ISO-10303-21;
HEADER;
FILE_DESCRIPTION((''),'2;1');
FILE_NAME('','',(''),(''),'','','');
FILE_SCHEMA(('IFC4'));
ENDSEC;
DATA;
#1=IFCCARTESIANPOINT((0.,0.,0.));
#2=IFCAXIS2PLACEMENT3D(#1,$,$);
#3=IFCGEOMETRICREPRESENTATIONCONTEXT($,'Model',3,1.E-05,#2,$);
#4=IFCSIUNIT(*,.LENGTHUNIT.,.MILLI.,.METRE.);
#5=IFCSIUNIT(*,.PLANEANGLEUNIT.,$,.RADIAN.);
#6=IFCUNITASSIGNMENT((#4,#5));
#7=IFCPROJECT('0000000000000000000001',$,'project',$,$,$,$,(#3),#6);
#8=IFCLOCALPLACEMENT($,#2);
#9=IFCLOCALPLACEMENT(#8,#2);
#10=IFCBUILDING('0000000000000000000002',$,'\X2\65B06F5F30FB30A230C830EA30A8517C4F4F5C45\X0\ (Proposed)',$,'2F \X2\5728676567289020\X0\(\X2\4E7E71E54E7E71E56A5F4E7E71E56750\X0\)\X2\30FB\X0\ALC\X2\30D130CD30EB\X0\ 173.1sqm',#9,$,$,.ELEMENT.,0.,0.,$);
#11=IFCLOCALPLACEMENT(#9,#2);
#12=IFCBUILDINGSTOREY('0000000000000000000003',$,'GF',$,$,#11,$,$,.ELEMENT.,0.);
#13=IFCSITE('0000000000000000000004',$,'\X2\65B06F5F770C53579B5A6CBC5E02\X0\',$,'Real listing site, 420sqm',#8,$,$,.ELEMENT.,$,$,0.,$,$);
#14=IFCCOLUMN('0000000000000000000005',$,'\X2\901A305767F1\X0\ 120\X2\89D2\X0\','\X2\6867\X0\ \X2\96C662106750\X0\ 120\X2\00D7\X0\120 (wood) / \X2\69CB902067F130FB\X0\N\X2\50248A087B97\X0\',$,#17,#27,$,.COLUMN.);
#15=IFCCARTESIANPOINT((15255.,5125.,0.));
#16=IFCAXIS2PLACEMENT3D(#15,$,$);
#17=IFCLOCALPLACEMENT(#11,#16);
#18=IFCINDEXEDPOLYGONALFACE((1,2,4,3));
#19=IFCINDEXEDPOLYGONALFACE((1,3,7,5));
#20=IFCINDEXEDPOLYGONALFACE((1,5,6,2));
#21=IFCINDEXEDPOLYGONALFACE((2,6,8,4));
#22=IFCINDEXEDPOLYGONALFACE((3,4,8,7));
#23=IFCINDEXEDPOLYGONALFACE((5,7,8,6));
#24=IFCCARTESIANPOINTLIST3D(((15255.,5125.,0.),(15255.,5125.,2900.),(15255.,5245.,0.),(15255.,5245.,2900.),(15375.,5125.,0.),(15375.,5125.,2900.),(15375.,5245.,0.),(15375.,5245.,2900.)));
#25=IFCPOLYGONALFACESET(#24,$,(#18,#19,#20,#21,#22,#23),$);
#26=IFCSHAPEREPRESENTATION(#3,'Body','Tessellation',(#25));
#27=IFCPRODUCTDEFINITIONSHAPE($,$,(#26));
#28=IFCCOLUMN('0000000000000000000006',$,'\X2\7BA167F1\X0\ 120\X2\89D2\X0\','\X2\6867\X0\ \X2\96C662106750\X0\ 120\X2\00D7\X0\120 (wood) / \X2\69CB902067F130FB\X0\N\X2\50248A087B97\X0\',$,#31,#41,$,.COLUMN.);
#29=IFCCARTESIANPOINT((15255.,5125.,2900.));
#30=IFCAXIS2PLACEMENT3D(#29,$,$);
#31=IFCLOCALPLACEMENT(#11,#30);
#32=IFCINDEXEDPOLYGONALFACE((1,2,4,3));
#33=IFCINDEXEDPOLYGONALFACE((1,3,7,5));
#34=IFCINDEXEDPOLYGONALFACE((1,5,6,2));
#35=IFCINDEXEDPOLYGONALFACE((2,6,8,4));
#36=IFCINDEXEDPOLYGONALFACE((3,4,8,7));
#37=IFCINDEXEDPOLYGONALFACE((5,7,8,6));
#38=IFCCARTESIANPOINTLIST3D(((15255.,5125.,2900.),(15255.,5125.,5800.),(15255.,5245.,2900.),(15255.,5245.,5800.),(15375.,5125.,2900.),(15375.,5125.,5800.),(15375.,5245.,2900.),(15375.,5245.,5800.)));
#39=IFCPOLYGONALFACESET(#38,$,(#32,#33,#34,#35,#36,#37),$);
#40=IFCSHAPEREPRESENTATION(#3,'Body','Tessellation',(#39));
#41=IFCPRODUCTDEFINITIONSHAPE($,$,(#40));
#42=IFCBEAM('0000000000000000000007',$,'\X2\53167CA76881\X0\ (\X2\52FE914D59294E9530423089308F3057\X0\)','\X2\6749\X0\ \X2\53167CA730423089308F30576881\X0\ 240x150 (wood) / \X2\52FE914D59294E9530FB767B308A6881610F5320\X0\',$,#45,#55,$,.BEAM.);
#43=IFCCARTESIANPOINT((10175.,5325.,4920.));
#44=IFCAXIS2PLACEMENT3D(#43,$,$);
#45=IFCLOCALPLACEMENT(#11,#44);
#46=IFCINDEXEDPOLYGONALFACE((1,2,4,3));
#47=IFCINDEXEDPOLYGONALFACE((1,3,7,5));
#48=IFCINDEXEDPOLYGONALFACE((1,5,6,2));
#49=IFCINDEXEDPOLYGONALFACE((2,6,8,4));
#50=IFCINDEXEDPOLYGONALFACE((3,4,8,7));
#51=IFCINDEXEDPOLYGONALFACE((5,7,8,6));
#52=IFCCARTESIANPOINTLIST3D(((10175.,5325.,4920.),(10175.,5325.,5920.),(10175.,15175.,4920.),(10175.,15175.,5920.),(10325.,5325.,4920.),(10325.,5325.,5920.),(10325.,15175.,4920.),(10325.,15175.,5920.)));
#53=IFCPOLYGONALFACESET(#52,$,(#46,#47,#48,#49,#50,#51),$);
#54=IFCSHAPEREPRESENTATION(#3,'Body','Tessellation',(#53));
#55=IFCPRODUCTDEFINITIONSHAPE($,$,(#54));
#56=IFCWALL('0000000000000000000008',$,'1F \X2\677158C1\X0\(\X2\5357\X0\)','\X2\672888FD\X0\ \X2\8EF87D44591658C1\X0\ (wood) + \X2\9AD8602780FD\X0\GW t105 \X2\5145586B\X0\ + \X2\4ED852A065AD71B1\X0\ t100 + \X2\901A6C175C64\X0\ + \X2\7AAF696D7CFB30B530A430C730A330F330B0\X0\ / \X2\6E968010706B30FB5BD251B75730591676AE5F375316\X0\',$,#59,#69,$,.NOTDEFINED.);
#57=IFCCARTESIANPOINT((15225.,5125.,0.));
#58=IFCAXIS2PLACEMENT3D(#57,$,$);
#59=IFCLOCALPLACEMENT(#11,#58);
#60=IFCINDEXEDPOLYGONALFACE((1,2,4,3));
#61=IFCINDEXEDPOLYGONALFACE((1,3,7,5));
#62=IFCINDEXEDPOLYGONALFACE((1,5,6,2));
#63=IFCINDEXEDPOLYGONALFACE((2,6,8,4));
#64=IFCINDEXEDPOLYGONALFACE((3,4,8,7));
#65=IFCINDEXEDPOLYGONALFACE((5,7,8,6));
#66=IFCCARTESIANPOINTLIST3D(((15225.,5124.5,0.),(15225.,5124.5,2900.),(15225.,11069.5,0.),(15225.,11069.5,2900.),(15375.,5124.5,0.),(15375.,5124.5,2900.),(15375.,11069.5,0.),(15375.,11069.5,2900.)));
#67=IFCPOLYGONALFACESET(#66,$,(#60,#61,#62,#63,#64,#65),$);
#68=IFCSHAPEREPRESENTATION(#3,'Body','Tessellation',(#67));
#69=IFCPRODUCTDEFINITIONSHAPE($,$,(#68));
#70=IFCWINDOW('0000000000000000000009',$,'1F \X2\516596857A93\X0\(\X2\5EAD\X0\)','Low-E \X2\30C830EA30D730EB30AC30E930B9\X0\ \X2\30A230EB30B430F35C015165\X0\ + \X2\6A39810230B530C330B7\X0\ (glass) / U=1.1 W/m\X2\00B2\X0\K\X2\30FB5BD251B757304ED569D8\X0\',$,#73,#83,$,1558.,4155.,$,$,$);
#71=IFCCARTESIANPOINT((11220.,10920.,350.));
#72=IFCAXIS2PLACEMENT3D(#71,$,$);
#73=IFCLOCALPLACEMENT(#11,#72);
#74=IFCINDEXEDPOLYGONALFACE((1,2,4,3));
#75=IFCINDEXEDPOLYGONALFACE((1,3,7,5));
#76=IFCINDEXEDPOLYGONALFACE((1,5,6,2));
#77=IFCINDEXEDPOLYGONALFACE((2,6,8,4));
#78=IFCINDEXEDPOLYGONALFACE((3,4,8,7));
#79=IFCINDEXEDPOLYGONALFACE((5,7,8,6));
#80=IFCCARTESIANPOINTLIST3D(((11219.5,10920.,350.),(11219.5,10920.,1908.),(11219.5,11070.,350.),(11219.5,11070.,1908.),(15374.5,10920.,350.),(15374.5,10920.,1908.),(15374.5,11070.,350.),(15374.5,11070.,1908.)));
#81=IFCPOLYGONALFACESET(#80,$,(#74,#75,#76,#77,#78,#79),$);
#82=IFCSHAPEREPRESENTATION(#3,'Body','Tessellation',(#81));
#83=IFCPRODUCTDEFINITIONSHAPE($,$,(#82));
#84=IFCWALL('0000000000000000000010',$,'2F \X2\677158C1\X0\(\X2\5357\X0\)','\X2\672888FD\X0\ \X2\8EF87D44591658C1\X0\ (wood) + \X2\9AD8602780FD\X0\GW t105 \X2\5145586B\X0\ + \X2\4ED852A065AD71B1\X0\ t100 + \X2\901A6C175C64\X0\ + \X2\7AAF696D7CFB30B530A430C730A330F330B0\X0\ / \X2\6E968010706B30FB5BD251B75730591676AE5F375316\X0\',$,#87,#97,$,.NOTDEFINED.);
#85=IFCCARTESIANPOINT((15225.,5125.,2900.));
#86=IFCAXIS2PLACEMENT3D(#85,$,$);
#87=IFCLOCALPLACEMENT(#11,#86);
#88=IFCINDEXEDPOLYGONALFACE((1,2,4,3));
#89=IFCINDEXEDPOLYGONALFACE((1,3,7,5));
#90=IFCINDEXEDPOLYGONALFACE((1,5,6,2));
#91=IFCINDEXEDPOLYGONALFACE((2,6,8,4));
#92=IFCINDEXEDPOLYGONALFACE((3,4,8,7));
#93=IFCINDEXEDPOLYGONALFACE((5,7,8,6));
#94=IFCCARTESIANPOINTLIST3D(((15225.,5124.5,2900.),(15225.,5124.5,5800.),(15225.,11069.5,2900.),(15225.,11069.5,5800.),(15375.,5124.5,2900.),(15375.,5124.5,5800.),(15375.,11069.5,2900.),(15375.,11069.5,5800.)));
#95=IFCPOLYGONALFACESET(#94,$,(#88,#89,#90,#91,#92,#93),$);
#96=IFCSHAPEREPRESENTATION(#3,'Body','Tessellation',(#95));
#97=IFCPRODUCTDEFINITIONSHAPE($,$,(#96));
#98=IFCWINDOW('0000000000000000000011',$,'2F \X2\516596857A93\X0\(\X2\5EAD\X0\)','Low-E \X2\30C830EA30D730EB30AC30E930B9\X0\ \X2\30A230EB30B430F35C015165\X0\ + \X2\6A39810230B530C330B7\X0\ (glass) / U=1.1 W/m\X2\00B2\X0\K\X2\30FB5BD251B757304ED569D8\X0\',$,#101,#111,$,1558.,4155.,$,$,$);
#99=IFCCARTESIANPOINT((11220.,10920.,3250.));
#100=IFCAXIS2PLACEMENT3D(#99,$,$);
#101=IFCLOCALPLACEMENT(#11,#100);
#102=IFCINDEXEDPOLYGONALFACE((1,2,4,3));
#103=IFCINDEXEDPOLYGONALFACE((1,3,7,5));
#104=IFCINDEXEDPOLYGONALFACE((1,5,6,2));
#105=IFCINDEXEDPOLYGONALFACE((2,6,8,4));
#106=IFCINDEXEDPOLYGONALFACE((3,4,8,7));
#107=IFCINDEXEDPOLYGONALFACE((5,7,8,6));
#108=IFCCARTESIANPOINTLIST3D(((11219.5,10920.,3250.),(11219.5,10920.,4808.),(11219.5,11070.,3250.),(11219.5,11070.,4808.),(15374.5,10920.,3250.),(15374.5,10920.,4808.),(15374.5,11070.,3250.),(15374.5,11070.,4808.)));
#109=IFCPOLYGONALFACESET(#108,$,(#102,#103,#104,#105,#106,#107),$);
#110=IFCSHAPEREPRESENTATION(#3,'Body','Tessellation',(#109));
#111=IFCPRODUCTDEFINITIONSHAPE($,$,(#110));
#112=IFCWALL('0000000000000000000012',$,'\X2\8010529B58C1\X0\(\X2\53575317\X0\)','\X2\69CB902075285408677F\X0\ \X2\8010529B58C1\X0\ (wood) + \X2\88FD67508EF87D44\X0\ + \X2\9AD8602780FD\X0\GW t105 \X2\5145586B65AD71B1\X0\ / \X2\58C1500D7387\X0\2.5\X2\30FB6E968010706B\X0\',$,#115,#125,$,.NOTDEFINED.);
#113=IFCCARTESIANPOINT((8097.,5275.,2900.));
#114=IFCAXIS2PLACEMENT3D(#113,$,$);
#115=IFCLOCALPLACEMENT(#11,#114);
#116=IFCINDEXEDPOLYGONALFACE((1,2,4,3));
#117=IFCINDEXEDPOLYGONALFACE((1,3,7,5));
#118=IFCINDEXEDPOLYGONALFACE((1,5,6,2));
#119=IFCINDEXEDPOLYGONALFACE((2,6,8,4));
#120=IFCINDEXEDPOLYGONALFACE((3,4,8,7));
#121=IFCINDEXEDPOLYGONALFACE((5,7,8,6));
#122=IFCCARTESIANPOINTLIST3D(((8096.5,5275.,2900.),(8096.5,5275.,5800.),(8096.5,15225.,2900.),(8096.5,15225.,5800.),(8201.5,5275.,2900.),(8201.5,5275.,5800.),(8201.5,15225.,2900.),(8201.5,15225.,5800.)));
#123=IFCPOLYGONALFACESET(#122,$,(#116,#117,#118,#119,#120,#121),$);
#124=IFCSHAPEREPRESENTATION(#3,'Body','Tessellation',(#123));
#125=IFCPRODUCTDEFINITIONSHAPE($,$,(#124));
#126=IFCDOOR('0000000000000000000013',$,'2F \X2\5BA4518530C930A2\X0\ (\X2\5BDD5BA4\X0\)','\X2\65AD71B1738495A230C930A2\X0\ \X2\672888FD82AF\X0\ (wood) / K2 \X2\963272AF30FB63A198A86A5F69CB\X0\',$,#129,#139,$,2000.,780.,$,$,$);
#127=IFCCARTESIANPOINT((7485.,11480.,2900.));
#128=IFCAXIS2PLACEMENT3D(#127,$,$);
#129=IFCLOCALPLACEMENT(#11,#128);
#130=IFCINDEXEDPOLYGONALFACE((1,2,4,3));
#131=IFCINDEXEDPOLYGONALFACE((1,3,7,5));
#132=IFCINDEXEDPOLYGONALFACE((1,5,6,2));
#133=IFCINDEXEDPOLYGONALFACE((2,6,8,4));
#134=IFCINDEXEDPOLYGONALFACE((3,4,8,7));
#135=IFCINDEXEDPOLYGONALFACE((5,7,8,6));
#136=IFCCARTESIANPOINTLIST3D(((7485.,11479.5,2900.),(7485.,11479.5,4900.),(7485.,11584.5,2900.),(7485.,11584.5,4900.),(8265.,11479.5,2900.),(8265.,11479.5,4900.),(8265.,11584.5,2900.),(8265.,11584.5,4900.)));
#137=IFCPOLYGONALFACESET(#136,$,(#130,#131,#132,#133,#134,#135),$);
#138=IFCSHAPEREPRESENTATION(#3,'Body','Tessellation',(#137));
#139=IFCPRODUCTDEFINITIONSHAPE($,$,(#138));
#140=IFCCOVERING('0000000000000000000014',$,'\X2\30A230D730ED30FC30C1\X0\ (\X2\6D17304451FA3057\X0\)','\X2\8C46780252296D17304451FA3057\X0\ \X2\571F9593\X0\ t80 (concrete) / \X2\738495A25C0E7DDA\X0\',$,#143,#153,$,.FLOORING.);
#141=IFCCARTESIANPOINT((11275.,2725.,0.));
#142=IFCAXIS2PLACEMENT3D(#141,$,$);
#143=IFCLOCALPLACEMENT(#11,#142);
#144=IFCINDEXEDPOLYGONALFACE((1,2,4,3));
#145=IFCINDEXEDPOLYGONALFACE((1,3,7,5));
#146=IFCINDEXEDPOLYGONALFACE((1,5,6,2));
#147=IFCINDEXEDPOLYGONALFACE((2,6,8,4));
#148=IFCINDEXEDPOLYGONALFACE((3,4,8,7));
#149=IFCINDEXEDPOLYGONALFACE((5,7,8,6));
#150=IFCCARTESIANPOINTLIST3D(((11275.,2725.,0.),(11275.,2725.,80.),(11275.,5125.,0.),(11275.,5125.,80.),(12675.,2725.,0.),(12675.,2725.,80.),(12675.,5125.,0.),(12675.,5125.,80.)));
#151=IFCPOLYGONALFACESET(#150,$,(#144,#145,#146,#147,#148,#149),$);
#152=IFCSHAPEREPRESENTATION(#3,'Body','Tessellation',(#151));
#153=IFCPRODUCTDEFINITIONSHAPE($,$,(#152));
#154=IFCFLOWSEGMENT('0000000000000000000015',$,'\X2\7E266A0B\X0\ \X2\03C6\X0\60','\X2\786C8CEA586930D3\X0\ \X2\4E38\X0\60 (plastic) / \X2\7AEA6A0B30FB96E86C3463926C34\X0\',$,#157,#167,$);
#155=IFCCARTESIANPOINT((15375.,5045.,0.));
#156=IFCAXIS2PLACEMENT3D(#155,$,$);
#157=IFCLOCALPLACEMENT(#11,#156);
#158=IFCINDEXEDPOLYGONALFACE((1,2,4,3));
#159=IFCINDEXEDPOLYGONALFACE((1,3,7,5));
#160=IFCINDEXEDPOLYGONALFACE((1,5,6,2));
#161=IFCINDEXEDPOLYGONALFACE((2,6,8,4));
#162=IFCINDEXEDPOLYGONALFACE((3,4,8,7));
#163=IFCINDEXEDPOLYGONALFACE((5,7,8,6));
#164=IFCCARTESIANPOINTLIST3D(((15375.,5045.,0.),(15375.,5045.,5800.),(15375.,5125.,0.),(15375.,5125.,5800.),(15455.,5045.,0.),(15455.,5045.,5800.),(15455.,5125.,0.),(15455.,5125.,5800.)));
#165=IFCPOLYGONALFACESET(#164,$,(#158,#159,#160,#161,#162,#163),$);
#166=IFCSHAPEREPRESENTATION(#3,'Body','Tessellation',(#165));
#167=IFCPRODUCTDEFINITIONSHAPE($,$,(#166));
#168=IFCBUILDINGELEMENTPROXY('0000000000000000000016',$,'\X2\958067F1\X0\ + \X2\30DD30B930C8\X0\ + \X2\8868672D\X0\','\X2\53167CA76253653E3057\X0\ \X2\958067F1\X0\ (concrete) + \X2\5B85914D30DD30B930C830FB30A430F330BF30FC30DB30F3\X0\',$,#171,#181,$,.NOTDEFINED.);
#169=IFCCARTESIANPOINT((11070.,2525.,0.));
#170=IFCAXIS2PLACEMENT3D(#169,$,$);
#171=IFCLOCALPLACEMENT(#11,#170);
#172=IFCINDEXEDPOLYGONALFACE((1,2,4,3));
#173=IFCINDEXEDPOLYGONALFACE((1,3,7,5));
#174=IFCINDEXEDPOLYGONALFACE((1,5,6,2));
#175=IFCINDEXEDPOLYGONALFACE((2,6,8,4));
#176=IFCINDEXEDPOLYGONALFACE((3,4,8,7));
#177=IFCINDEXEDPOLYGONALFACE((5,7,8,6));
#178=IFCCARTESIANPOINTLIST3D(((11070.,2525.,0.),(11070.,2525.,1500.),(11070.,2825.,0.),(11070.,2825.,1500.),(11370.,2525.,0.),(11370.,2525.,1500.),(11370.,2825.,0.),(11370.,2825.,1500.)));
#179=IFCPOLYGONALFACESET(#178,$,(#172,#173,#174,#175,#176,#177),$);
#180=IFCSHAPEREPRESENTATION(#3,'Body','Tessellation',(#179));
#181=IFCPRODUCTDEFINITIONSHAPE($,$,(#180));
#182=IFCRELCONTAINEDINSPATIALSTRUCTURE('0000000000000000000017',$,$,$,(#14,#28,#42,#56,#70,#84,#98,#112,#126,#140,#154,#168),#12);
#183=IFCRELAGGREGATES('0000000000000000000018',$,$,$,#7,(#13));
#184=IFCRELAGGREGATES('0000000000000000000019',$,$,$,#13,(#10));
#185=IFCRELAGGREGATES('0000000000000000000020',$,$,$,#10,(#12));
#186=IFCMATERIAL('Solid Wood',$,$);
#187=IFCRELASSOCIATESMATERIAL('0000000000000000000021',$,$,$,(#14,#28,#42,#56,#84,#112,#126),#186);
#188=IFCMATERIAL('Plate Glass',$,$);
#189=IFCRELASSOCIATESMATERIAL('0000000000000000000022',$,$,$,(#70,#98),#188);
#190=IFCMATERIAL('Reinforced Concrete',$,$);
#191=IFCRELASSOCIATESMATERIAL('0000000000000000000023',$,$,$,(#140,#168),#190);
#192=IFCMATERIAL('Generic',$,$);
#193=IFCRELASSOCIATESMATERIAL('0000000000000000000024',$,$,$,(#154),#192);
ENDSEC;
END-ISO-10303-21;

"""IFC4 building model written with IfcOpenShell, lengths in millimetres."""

from ifc_helpers import new_model, si_unit, frame, frame_2d, origin, place, context, project, spatial, rectangle, extrude, material, element, fill, save


model = new_model("IFC4")

# Units and contexts
model_context = context("Model", 3, precision=1e-05, world=origin())
ifc_project = project(units=[si_unit("LENGTHUNIT", "METRE", prefix="MILLI"), si_unit("PLANEANGLEUNIT", "RADIAN")], contexts=[model_context])

# Site, building, storey
site_placement = place(None, origin())
site = spatial("IfcSite", under=ifc_project, at=site_placement, Name="新潟県南魚沼市", ObjectType="Real listing site, 420sqm", CompositionType="ELEMENT", RefElevation=0.0)
building_placement = place(site_placement, origin())
building = spatial("IfcBuilding", under=site, at=building_placement, Name="新潟・アトリエ兼住居 (Proposed)", ObjectType="2F 在来木造(乾燥乾燥機乾燥材)・ALCパネル 173.1sqm", CompositionType="ELEMENT", ElevationOfRefHeight=0.0, ElevationOfTerrain=0.0)
storey_placement = place(building_placement, origin())
storey = spatial("IfcBuildingStorey", under=building, at=storey_placement, Name="GF", CompositionType="ELEMENT", Elevation=0.0)

# Columns
ifc_material_1 = material(Name="Solid Wood")
column_1_placement = place(storey_placement, frame((15255.0, 5125.0, 0.0)))
element("IfcColumn", 1, at=column_1_placement, inside=storey, material=ifc_material_1, Name="通し柱 120角", Description="桧 集成材 120×120 (wood) / 構造柱・N値計算", PredefinedType="COLUMN", context=model_context, shape_type="SweptSolid", body=[
    extrude(rectangle(XDim=120.0, YDim=120.0, at=frame_2d((60.0, 60.0))), frame((15255.0, 5125.0, 0.0)), (0.0, 0.0, 1.0), 2900.0),
])
column_2_placement = place(storey_placement, frame((15255.0, 5125.0, 2900.0)))
element("IfcColumn", 2, at=column_2_placement, inside=storey, material=ifc_material_1, Name="管柱 120角", Description="桧 集成材 120×120 (wood) / 構造柱・N値計算", PredefinedType="COLUMN", context=model_context, shape_type="SweptSolid", body=[
    extrude(rectangle(XDim=120.0, YDim=120.0, at=frame_2d((60.0, 60.0))), frame((15255.0, 5125.0, 2900.0)), (0.0, 0.0, 1.0), 2900.0),
])

# Beam
beam_1_placement = place(storey_placement, frame((10175.0, 5325.0, 4920.0)))
element("IfcBeam", 3, at=beam_1_placement, inside=storey, material=ifc_material_1, Name="化粧梁 (勾配天井あらわし)", Description="杉 化粧あらわし梁 240x150 (wood) / 勾配天井・登り梁意匠", PredefinedType="BEAM", context=model_context, shape_type="SweptSolid", body=[
    extrude(rectangle(XDim=150.0, YDim=9850.0, at=frame_2d((75.0, 4925.0))), frame((10175.0, 5325.0, 4920.0)), (0.0, 0.0, 1.0), 1000.0),
])

# Wall, opening, window
wall_1_placement = place(storey_placement, frame((15225.0, 5125.0, 0.0)))
wall_1 = element("IfcWall", 4, at=wall_1_placement, inside=storey, material=ifc_material_1, Name="1F 東壁(南)", Description="木製 軸組外壁 (wood) + 高性能GW t105 充填 + 付加断熱 t100 + 通気層 + 窯業系サイディング / 準耐火・寒冷地外皮強化", PredefinedType="NOTDEFINED", context=model_context, shape_type="SweptSolid", body=[
    extrude(rectangle(XDim=150.0, YDim=5945.0, at=frame_2d((75.0, 2972.0))), frame((15225.0, 5125.0, 0.0)), (0.0, 0.0, 1.0), 2900.0),
])
opening_1_placement = place(storey_placement, frame((11220.0, 10920.0, 350.0)))
opening_1 = element("IfcOpeningElement", 5, at=opening_1_placement, cuts=wall_1, PredefinedType="NOTDEFINED", context=model_context, shape_type="SweptSolid", body=[
    extrude(rectangle(XDim=4155.0, YDim=150.0, at=frame_2d((2077.0, 75.0))), frame((11220.0, 10920.0, 350.0)), (0.0, 0.0, 1.0), 1558.0),
])
ifc_material_2 = material(Name="Plate Glass")
window_1_placement = place(storey_placement, frame((11220.0, 10920.0, 350.0)))
window_1 = element("IfcWindow", 6, at=window_1_placement, inside=storey, material=ifc_material_2, Name="1F 入隅窓(庭)", Description="Low-E トリプルガラス アルゴン封入 + 樹脂サッシ (glass) / U=1.1 W/m²K・寒冷地仕様", OverallHeight=1558.0, OverallWidth=4155.0, context=model_context, shape_type="SweptSolid", body=[
    extrude(rectangle(XDim=4155.0, YDim=150.0, at=frame_2d((2077.0, 75.0))), frame((11220.0, 10920.0, 350.0)), (0.0, 0.0, 1.0), 1558.0),
])
fill(opening_1, window_1)

# Wall, opening, window
wall_2_placement = place(storey_placement, frame((15225.0, 5125.0, 2900.0)))
wall_2 = element("IfcWall", 7, at=wall_2_placement, inside=storey, material=ifc_material_1, Name="2F 東壁(南)", Description="木製 軸組外壁 (wood) + 高性能GW t105 充填 + 付加断熱 t100 + 通気層 + 窯業系サイディング / 準耐火・寒冷地外皮強化", PredefinedType="NOTDEFINED", context=model_context, shape_type="SweptSolid", body=[
    extrude(rectangle(XDim=150.0, YDim=5945.0, at=frame_2d((75.0, 2972.0))), frame((15225.0, 5125.0, 2900.0)), (0.0, 0.0, 1.0), 2900.0),
])
opening_2_placement = place(storey_placement, frame((11220.0, 10920.0, 3250.0)))
opening_2 = element("IfcOpeningElement", 8, at=opening_2_placement, cuts=wall_2, PredefinedType="NOTDEFINED", context=model_context, shape_type="SweptSolid", body=[
    extrude(rectangle(XDim=4155.0, YDim=150.0, at=frame_2d((2077.0, 75.0))), frame((11220.0, 10920.0, 3250.0)), (0.0, 0.0, 1.0), 1558.0),
])
window_2_placement = place(storey_placement, frame((11220.0, 10920.0, 3250.0)))
window_2 = element("IfcWindow", 9, at=window_2_placement, inside=storey, material=ifc_material_2, Name="2F 入隅窓(庭)", Description="Low-E トリプルガラス アルゴン封入 + 樹脂サッシ (glass) / U=1.1 W/m²K・寒冷地仕様", OverallHeight=1558.0, OverallWidth=4155.0, context=model_context, shape_type="SweptSolid", body=[
    extrude(rectangle(XDim=4155.0, YDim=150.0, at=frame_2d((2077.0, 75.0))), frame((11220.0, 10920.0, 3250.0)), (0.0, 0.0, 1.0), 1558.0),
])
fill(opening_2, window_2)

# Wall, opening, door
wall_3_placement = place(storey_placement, frame((8097.0, 5275.0, 2900.0)))
wall_3 = element("IfcWall", 10, at=wall_3_placement, inside=storey, material=ifc_material_1, Name="耐力壁(南北)", Description="構造用合板 耐力壁 (wood) + 製材軸組 + 高性能GW t105 充填断熱 / 壁倍率2.5・準耐火", PredefinedType="NOTDEFINED", context=model_context, shape_type="SweptSolid", body=[
    extrude(rectangle(XDim=105.0, YDim=9950.0, at=frame_2d((52.0, 4975.0))), frame((8097.0, 5275.0, 2900.0)), (0.0, 0.0, 1.0), 2900.0),
])
opening_3_placement = place(storey_placement, frame((7485.0, 11480.0, 2900.0)))
opening_3 = element("IfcOpeningElement", 11, at=opening_3_placement, cuts=wall_3, PredefinedType="NOTDEFINED", context=model_context, shape_type="SweptSolid", body=[
    extrude(rectangle(XDim=780.0, YDim=105.0, at=frame_2d((390.0, 52.0))), frame((7485.0, 11480.0, 2900.0)), (0.0, 0.0, 1.0), 2000.0),
])
door_1_placement = place(storey_placement, frame((7485.0, 11480.0, 2900.0)))
door_1 = element("IfcDoor", 12, at=door_1_placement, inside=storey, material=ifc_material_1, Name="2F 室内ドア (寝室)", Description="断熱玄関ドア 木製芯 (wood) / K2 防犯・採風機構", OverallHeight=2000.0, OverallWidth=780.0, context=model_context, shape_type="SweptSolid", body=[
    extrude(rectangle(XDim=780.0, YDim=105.0, at=frame_2d((390.0, 52.0))), frame((7485.0, 11480.0, 2900.0)), (0.0, 0.0, 1.0), 2000.0),
])
fill(opening_3, door_1)

# Covering
ifc_material_3 = material(Name="Reinforced Concrete")
covering_placement = place(storey_placement, frame((11275.0, 2725.0, 0.0)))
element("IfcCovering", 13, at=covering_placement, inside=storey, material=ifc_material_3, Name="アプローチ (洗い出し)", Description="豆砂利洗い出し 土間 t80 (concrete) / 玄関導線", PredefinedType="FLOORING", context=model_context, shape_type="SweptSolid", body=[
    extrude(rectangle(XDim=1400.0, YDim=2400.0, at=frame_2d((700.0, 1200.0))), frame((11275.0, 2725.0, 0.0)), (0.0, 0.0, 1.0), 80.0),
])

# Flow segment
ifc_material_4 = material(Name="Generic")
flow_segment_placement = place(storey_placement, frame((15375.0, 5045.0, 0.0)))
element("IfcFlowSegment", 14, at=flow_segment_placement, inside=storey, material=ifc_material_4, Name="縦樋 φ60", Description="硬質塩ビ 丸60 (plastic) / 竪樋・雨水排水", context=model_context, shape_type="SweptSolid", body=[
    extrude(rectangle(XDim=80.0, YDim=80.0, at=frame_2d((40.0, 40.0))), frame((15375.0, 5045.0, 0.0)), (0.0, 0.0, 1.0), 5800.0),
])

# Building element proxy
proxy_placement = place(storey_placement, frame((11070.0, 2525.0, 0.0)))
element("IfcBuildingElementProxy", 15, at=proxy_placement, inside=storey, material=ifc_material_3, Name="門柱 + ポスト + 表札", Description="化粧打放し 門柱 (concrete) + 宅配ポスト・インターホン", PredefinedType="NOTDEFINED", context=model_context, shape_type="SweptSolid", body=[
    extrude(rectangle(XDim=300.0, YDim=300.0, at=frame_2d((150.0, 150.0))), frame((11070.0, 2525.0, 0.0)), (0.0, 0.0, 1.0), 1500.0),
])

save(model, "model.ifc")
